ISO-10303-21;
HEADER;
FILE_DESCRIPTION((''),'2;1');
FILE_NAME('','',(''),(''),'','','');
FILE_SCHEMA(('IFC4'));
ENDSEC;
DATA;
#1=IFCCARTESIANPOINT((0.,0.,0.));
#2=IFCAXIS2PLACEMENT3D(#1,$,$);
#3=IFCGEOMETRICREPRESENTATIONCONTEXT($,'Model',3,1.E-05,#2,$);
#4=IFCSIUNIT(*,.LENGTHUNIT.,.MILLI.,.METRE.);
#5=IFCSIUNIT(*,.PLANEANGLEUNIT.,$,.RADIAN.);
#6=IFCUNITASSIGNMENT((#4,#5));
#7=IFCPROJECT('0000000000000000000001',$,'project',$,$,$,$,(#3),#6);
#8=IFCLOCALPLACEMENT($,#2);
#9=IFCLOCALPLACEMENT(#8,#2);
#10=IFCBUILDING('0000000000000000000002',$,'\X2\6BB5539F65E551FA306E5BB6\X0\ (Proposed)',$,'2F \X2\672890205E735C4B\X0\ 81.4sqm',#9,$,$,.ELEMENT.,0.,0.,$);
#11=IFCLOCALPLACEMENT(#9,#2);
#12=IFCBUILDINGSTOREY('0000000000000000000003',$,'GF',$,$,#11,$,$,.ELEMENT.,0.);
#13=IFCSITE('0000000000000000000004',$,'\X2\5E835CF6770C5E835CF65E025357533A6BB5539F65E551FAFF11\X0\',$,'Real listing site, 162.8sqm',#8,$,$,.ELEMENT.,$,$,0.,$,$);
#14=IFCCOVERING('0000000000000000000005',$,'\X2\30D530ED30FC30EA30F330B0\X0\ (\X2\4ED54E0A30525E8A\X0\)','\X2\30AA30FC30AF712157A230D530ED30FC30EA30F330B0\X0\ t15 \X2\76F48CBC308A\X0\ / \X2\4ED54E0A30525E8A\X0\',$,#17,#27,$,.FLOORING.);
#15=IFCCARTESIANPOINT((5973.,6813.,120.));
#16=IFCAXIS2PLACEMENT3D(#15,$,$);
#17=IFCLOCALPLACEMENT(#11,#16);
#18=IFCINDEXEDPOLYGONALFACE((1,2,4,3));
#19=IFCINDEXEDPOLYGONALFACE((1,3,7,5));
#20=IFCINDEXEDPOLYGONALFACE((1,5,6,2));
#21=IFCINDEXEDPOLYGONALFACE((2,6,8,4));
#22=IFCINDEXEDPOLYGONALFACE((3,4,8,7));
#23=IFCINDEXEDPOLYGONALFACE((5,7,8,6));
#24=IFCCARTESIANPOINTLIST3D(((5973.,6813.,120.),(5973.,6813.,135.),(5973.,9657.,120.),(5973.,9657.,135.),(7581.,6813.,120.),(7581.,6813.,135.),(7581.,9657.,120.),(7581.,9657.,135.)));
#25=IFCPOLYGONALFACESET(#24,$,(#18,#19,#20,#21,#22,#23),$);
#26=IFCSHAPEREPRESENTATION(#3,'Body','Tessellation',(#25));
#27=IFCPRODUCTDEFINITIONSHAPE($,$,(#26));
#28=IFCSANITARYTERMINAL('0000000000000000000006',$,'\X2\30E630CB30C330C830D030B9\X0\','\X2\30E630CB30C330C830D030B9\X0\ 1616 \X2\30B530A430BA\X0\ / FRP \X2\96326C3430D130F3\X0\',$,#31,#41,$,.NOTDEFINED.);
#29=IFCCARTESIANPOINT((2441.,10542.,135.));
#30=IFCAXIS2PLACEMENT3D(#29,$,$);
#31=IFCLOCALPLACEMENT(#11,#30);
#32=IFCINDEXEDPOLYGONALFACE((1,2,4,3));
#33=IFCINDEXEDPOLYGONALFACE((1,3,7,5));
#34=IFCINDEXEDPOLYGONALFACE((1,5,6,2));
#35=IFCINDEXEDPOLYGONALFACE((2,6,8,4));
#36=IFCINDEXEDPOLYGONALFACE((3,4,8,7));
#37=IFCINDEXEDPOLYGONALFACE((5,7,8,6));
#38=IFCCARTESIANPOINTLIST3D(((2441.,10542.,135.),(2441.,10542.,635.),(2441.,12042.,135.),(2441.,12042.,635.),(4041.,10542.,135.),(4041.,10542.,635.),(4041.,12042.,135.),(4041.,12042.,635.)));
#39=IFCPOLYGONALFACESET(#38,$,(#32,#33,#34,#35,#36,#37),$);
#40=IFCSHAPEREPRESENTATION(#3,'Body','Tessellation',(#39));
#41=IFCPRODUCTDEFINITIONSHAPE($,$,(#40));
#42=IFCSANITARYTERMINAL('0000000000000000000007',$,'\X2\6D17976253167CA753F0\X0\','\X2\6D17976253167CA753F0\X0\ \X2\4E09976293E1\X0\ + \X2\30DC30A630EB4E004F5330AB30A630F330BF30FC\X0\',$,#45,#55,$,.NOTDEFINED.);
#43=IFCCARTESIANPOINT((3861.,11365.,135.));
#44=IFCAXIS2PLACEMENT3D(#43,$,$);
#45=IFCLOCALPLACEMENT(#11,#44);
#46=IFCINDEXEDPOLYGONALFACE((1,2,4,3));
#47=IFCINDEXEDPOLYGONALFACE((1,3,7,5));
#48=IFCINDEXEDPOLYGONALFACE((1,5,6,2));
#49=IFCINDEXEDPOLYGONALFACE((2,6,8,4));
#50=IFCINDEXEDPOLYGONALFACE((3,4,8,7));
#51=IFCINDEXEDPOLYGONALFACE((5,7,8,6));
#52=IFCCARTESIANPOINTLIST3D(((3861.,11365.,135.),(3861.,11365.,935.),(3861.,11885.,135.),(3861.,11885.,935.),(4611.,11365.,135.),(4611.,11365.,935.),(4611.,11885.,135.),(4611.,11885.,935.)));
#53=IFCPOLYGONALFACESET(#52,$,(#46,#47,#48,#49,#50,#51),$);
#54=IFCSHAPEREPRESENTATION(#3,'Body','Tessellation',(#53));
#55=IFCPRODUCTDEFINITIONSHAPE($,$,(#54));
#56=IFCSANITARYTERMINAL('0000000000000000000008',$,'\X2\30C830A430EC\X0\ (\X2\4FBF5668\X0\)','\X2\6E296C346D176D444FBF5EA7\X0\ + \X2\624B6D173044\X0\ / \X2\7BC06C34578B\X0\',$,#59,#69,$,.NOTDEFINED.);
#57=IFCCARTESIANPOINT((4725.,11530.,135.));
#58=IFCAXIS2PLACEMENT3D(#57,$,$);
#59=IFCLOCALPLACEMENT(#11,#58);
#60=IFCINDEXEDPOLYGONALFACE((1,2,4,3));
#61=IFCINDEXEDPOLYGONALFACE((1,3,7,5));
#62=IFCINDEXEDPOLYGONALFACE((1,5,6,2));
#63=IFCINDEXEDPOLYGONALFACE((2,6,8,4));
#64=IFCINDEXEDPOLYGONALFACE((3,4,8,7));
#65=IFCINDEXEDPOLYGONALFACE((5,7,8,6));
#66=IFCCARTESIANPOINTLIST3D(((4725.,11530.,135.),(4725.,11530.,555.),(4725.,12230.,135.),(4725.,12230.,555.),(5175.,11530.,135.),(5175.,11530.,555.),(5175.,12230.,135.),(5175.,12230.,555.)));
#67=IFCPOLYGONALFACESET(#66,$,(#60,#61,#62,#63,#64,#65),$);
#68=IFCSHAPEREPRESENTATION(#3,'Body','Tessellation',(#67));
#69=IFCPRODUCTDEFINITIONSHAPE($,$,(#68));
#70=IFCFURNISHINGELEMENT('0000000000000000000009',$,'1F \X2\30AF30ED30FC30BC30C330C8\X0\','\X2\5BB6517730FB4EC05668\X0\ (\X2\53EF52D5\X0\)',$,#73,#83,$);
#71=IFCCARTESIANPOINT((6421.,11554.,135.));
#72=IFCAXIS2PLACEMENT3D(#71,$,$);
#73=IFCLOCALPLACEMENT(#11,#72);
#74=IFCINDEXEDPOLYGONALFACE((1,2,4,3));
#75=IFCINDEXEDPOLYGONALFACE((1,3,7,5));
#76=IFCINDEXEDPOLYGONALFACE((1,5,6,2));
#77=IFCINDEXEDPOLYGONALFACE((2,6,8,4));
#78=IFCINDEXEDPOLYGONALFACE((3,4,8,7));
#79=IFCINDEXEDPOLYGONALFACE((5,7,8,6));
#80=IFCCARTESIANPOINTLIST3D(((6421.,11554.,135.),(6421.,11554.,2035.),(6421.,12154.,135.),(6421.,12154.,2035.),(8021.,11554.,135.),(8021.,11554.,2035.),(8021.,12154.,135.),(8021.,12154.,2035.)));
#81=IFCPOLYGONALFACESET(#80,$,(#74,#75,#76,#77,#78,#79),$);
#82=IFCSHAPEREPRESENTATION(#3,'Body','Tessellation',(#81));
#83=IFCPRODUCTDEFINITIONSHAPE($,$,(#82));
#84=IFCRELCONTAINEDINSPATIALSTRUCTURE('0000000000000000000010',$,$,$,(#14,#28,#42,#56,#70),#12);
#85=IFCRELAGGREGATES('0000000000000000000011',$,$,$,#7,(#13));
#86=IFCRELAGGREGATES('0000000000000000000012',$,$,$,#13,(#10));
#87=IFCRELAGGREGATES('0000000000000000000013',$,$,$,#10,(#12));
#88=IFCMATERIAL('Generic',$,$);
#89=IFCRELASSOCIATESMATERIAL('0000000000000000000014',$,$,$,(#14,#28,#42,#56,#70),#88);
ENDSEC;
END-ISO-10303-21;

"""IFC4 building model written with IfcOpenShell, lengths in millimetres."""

from ifc_helpers import new_model, si_unit, frame, frame_2d, origin, place, context, project, spatial, rectangle, extrude, material, element, save


model = new_model("IFC4")

# Units and contexts
model_context = context("Model", 3, precision=1e-05, world=origin())
ifc_project = project(units=[si_unit("LENGTHUNIT", "METRE", prefix="MILLI"), si_unit("PLANEANGLEUNIT", "RADIAN")], contexts=[model_context])

# Site, building, storey
site_placement = place(None, origin())
site = spatial("IfcSite", under=ifc_project, at=site_placement, Name="広島県広島市南区段原日出１", ObjectType="Real listing site, 162.8sqm", CompositionType="ELEMENT", RefElevation=0.0)
building_placement = place(site_placement, origin())
building = spatial("IfcBuilding", under=site, at=building_placement, Name="段原日出の家 (Proposed)", ObjectType="2F 木造平屋 81.4sqm", CompositionType="ELEMENT", ElevationOfRefHeight=0.0, ElevationOfTerrain=0.0)
storey_placement = place(building_placement, origin())
storey = spatial("IfcBuildingStorey", under=building, at=storey_placement, Name="GF", CompositionType="ELEMENT", Elevation=0.0)

# Covering
ifc_material_1 = material(Name="Generic")
covering_1_placement = place(storey_placement, frame((5973.0, 6813.0, 120.0)))
element("IfcCovering", 1, at=covering_1_placement, inside=storey, material=ifc_material_1, Name="フローリング (仕上げ床)", Description="オーク無垢フローリング t15 直貼り / 仕上げ床", PredefinedType="FLOORING", context=model_context, shape_type="SweptSolid", body=[
    extrude(rectangle(XDim=1608.0, YDim=2844.0, at=frame_2d((804.0, 1422.0))), frame((5973.0, 6813.0, 120.0)), (0.0, 0.0, 1.0), 15.0),
])

# Sanitary terminals
sanitary_terminal_1_placement = place(storey_placement, frame((2441.0, 10542.0, 135.0)))
element("IfcSanitaryTerminal", 2, at=sanitary_terminal_1_placement, inside=storey, material=ifc_material_1, Name="ユニットバス", Description="ユニットバス 1616 サイズ / FRP 防水パン", PredefinedType="NOTDEFINED", context=model_context, shape_type="SweptSolid", body=[
    extrude(rectangle(XDim=1600.0, YDim=1500.0, at=frame_2d((800.0, 750.0))), frame((2441.0, 10542.0, 135.0)), (0.0, 0.0, 1.0), 500.0),
])
sanitary_terminal_2_placement = place(storey_placement, frame((3861.0, 11365.0, 135.0)))
element("IfcSanitaryTerminal", 3, at=sanitary_terminal_2_placement, inside=storey, material=ifc_material_1, Name="洗面化粧台", Description="洗面化粧台 三面鏡 + ボウル一体カウンター", PredefinedType="NOTDEFINED", context=model_context, shape_type="SweptSolid", body=[
    extrude(rectangle(XDim=750.0, YDim=520.0, at=frame_2d((375.0, 260.0))), frame((3861.0, 11365.0, 135.0)), (0.0, 0.0, 1.0), 800.0),
])
sanitary_terminal_3_placement = place(storey_placement, frame((4725.0, 11530.0, 135.0)))
element("IfcSanitaryTerminal", 4, at=sanitary_terminal_3_placement, inside=storey, material=ifc_material_1, Name="トイレ (便器)", Description="温水洗浄便座 + 手洗い / 節水型", PredefinedType="NOTDEFINED", context=model_context, shape_type="SweptSolid", body=[
    extrude(rectangle(XDim=450.0, YDim=700.0, at=frame_2d((225.0, 350.0))), frame((4725.0, 11530.0, 135.0)), (0.0, 0.0, 1.0), 420.0),
])

# Furnishing element
furnishing_placement = place(storey_placement, frame((6421.0, 11554.0, 135.0)))
element("IfcFurnishingElement", 5, at=furnishing_placement, inside=storey, material=ifc_material_1, Name="1F クローゼット", Description="家具・什器 (可動)", context=model_context, shape_type="SweptSolid", body=[
    extrude(rectangle(XDim=1600.0, YDim=600.0, at=frame_2d((800.0, 300.0))), frame((6421.0, 11554.0, 135.0)), (0.0, 0.0, 1.0), 1900.0),
])

save(model, "model.ifc")
